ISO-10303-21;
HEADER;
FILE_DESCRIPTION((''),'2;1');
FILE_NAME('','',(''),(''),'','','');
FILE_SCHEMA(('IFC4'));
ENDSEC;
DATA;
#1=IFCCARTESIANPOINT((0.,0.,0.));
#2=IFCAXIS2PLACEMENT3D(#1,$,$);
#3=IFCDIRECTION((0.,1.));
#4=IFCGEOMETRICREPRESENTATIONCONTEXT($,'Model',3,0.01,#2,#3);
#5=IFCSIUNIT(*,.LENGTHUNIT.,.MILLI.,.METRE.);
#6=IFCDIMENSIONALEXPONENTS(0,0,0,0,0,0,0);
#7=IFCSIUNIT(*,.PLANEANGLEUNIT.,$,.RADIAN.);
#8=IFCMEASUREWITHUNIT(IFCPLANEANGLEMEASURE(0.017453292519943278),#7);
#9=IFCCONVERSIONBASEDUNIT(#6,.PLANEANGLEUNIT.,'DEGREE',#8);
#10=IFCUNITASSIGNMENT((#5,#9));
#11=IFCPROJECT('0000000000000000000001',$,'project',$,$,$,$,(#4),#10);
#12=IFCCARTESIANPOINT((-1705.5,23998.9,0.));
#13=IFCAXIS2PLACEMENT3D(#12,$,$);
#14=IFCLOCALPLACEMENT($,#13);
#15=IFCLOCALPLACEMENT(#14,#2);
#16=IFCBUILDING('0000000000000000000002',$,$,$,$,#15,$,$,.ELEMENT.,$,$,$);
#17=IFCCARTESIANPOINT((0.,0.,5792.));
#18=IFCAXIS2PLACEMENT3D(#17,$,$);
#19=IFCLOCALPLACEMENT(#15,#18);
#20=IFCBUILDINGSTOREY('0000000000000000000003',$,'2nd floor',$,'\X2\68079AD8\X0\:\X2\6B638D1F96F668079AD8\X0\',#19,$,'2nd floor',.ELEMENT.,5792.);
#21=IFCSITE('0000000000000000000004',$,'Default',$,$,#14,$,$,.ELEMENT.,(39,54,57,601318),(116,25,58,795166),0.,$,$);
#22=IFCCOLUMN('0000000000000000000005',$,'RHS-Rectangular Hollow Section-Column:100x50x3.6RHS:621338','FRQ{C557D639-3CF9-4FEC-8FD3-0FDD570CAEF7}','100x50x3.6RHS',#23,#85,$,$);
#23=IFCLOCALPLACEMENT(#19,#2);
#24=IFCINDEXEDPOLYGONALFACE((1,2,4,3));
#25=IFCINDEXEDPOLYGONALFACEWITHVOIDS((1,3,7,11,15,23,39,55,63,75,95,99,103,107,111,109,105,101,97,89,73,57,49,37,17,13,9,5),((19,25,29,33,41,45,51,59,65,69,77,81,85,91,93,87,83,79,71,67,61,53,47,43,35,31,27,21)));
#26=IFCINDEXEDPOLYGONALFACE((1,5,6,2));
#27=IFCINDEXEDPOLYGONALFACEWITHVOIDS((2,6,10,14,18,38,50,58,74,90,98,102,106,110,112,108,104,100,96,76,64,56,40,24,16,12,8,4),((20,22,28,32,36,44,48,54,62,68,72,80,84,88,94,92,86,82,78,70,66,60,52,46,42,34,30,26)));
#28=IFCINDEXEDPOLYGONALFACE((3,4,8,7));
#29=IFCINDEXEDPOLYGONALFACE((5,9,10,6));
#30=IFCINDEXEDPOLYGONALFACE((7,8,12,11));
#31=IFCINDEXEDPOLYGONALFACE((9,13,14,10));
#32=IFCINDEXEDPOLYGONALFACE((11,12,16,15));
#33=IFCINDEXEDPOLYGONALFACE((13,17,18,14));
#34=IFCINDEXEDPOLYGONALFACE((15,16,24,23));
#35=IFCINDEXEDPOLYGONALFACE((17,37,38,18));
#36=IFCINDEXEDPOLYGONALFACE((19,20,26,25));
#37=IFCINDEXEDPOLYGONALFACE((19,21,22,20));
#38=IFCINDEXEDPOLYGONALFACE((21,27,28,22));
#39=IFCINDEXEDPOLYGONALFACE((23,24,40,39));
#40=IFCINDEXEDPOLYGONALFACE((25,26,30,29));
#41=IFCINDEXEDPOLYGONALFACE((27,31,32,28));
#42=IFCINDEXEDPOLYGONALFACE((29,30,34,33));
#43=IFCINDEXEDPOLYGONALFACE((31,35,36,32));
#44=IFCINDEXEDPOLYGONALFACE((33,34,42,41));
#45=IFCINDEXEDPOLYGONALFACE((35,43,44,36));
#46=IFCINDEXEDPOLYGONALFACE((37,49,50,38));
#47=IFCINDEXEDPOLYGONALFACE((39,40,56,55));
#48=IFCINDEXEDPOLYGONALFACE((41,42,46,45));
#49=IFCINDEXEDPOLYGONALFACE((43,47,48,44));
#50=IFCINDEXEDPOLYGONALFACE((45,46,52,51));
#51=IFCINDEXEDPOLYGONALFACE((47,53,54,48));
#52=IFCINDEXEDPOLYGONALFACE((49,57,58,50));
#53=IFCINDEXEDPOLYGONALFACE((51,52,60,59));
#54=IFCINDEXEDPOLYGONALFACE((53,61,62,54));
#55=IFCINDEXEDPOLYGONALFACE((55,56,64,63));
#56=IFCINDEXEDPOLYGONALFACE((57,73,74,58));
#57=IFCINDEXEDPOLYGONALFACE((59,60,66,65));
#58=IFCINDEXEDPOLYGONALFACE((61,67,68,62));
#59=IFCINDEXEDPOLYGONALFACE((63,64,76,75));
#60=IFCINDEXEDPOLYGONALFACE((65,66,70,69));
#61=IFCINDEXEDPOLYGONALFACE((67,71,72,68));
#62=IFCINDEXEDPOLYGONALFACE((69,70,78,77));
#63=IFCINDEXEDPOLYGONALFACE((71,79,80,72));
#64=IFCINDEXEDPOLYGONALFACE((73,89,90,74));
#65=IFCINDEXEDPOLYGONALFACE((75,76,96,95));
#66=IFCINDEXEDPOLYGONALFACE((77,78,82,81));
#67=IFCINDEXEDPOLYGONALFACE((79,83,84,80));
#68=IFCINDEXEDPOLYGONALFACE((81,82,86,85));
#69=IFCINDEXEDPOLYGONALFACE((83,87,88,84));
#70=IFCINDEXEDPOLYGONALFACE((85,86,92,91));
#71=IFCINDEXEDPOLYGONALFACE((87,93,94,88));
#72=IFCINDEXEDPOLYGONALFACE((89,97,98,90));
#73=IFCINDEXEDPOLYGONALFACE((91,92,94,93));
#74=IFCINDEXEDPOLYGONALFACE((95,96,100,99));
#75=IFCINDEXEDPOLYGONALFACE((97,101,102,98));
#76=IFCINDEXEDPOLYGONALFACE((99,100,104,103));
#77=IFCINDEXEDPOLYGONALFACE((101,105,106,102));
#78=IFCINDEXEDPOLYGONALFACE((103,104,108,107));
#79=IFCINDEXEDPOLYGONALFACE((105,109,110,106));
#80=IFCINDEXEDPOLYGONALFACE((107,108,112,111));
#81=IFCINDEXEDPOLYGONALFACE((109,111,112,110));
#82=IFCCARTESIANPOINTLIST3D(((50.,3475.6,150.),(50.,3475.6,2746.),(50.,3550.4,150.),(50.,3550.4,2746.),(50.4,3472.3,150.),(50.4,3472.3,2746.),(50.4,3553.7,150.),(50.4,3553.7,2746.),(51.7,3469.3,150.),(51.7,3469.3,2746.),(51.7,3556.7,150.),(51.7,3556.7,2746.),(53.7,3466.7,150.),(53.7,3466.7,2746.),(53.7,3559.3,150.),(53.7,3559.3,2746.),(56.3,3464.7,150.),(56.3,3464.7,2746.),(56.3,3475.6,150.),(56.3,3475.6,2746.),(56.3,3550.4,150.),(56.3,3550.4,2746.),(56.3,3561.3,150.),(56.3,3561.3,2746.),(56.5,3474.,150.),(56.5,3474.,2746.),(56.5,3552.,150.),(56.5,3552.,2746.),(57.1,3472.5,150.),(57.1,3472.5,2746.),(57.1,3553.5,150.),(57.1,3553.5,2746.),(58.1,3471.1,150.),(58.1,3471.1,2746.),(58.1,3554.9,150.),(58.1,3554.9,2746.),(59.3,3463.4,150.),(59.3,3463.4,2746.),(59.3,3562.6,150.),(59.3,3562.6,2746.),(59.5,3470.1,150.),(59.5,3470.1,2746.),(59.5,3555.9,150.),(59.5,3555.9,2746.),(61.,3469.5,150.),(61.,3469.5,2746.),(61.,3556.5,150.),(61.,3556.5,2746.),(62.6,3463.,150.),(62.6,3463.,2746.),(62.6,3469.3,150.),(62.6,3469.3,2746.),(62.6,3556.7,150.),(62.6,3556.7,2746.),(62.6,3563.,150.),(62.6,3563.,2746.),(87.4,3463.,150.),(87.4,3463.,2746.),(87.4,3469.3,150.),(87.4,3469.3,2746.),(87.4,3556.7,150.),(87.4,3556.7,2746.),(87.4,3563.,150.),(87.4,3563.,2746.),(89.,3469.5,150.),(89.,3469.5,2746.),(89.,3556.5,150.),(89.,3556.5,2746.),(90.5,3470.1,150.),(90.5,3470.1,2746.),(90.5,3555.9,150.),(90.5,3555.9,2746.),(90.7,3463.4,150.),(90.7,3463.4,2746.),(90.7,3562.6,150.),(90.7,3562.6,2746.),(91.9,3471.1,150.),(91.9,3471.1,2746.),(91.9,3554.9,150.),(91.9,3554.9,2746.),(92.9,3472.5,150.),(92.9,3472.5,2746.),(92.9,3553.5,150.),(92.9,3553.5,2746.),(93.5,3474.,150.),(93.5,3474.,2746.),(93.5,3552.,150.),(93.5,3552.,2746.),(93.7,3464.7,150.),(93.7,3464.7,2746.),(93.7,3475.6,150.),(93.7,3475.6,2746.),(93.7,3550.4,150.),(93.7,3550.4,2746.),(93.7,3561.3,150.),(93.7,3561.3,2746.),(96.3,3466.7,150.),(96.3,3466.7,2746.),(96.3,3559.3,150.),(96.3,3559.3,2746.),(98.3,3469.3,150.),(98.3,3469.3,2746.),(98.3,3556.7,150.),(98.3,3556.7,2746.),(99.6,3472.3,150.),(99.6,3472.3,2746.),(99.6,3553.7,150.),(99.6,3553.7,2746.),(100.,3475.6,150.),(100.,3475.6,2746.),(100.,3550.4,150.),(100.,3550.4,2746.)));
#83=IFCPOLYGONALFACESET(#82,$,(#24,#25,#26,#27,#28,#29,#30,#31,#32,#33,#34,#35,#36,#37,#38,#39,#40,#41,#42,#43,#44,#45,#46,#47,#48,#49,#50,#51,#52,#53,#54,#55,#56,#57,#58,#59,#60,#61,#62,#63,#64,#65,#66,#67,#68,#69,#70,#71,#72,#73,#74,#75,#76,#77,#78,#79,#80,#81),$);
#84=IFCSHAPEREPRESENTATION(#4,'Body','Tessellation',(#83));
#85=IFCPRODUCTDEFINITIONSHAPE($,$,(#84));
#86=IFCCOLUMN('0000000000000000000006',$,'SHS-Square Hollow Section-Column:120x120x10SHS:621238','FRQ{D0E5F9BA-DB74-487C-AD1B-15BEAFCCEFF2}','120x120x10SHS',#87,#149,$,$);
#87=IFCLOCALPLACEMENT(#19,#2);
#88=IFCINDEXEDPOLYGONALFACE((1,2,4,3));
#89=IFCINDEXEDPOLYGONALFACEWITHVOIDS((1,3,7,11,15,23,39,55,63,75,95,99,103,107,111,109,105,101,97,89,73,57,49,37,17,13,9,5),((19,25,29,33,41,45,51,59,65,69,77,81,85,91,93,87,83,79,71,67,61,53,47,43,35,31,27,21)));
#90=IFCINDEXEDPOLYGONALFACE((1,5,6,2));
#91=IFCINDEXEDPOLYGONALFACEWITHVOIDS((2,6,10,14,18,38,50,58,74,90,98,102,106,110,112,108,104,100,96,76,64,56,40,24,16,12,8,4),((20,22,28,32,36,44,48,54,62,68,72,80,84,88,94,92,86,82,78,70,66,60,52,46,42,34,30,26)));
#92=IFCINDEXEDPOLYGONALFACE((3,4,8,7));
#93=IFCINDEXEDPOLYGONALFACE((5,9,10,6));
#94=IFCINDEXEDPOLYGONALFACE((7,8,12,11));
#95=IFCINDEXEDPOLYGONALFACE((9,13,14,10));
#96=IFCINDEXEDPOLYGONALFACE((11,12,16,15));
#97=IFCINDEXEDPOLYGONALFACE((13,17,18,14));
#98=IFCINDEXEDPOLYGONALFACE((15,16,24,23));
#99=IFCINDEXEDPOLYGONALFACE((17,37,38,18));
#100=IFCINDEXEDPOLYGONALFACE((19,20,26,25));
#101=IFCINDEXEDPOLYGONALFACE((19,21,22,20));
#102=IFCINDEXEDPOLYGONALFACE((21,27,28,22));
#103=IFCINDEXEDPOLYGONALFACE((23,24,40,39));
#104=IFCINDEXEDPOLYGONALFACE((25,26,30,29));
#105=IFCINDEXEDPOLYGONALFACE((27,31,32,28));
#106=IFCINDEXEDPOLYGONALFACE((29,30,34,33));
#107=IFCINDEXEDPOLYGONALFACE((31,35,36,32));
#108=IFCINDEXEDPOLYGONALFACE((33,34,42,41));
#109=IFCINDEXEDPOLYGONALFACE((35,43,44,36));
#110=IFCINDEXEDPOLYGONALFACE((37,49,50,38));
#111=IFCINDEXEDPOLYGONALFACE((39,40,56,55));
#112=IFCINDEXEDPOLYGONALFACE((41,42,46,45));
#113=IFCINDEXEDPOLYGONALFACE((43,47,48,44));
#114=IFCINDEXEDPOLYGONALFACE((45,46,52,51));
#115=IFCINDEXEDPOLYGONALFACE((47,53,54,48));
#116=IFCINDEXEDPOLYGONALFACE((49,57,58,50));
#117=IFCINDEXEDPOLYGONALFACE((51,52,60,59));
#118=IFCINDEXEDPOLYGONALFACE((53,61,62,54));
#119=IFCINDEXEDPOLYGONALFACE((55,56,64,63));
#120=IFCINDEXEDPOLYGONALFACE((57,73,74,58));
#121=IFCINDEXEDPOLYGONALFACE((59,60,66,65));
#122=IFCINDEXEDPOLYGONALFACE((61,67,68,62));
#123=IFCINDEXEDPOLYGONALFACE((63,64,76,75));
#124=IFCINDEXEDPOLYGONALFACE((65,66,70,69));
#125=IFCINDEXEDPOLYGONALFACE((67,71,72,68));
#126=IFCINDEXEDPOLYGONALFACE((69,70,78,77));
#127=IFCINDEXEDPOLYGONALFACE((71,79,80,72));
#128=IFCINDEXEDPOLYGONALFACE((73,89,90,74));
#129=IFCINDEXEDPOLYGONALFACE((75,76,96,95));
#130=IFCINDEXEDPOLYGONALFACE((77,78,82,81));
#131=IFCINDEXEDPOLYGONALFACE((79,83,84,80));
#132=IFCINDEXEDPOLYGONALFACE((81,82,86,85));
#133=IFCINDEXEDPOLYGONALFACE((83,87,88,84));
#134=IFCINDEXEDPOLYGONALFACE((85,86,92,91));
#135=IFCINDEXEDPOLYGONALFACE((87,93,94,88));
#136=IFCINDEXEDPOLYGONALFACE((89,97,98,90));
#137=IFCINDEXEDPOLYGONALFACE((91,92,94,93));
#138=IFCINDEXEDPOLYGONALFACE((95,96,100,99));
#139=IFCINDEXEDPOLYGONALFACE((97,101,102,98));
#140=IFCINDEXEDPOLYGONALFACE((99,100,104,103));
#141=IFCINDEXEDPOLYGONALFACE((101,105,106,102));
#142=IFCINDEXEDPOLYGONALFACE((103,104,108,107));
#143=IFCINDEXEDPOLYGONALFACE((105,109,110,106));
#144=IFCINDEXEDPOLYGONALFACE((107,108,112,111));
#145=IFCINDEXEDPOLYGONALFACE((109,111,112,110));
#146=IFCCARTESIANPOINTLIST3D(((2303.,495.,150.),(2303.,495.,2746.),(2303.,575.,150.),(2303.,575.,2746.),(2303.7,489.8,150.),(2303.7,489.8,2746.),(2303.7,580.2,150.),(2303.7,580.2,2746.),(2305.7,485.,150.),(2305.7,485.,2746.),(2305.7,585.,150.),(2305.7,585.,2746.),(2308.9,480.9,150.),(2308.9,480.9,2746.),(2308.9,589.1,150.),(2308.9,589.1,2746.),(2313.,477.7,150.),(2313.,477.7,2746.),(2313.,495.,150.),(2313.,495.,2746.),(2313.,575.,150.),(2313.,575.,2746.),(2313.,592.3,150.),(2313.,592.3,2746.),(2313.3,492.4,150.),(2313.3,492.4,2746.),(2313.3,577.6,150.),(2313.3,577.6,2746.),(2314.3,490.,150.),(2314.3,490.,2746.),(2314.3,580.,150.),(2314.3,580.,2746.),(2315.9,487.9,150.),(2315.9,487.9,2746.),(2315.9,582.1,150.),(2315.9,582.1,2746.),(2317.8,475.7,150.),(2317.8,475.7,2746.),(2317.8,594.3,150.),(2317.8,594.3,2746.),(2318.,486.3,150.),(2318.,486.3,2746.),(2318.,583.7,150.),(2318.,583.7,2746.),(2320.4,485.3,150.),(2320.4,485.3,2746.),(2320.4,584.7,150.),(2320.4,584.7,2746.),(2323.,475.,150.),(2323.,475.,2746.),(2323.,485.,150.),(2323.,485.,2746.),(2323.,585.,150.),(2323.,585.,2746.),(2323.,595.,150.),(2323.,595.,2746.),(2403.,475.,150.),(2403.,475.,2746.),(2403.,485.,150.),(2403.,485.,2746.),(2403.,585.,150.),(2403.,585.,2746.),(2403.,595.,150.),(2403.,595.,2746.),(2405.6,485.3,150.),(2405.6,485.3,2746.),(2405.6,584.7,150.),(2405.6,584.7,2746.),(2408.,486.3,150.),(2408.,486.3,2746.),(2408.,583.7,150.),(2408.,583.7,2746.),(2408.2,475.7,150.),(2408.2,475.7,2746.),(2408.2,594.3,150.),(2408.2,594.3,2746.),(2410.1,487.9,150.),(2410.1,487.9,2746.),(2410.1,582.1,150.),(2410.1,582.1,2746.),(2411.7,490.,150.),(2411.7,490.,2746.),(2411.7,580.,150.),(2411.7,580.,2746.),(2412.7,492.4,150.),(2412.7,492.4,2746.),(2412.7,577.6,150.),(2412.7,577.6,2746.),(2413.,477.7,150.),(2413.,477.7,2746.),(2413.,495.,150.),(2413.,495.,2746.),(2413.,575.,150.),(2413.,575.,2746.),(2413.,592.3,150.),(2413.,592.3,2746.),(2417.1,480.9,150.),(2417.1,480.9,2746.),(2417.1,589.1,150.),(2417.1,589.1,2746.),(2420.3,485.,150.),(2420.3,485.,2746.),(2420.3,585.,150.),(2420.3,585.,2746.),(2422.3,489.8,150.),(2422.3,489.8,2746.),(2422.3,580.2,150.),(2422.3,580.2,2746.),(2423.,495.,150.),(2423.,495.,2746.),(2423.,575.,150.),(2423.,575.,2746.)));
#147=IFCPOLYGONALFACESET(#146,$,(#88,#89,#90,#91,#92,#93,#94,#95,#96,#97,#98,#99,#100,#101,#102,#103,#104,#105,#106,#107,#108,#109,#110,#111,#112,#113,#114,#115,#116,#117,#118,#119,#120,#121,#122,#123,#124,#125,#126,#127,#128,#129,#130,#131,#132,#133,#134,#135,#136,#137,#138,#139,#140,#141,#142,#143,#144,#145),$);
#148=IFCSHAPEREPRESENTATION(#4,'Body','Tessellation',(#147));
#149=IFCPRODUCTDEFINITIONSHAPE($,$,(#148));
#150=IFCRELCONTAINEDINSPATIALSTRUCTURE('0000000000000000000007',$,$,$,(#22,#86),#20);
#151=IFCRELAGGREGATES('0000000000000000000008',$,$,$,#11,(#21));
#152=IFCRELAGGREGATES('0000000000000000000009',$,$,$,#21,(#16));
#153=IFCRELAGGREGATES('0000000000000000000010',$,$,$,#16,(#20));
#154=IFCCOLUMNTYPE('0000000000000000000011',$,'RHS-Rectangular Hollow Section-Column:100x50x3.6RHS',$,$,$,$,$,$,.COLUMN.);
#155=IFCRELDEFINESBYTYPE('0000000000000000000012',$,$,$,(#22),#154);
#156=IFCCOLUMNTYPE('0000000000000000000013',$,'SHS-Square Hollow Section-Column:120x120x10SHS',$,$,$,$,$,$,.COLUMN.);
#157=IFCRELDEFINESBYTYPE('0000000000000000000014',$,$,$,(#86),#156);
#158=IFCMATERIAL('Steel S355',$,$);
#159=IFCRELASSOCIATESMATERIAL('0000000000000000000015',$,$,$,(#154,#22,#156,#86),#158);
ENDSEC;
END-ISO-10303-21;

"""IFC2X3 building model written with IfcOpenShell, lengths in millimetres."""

from ifc_helpers import new_model, entity, si_unit, converted_unit, direction, frame, origin, origin_2d, place, context, project, spatial, hollow_rectangle, extrude, clip, halfspace, material, type_object, element, save


model = new_model("IFC2X3")

# Units and contexts
model_context = context("Model", 3, precision=0.01, world=origin(), true_north=direction((0.0, 1.0)))
ifc_project = project(units=[si_unit("LENGTHUNIT", "METRE", prefix="MILLI"), converted_unit("PLANEANGLEUNIT", "DEGREE", entity("IfcPlaneAngleMeasure", 0.017453292519943278), si_unit("PLANEANGLEUNIT", "RADIAN"), dimensions=[0, 0, 0, 0, 0, 0, 0])], contexts=[model_context])

# Site, building, storey
site_placement = place(None, frame((-1705.5, 23998.9, 0.0)))
site = spatial("IfcSite", under=ifc_project, at=site_placement, Name="Default", CompositionType="ELEMENT", RefLatitude=(39, 54, 57, 601318), RefLongitude=(116, 25, 58, 795166), RefElevation=0.0)
building_placement = place(site_placement, origin())
building = spatial("IfcBuilding", under=site, at=building_placement, CompositionType="ELEMENT")
storey_placement = place(building_placement, frame((0.0, 0.0, 5792.0)))
storey = spatial("IfcBuildingStorey", under=building, at=storey_placement, Name="2nd floor", ObjectType="标高:正负零标高", LongName="2nd floor", CompositionType="ELEMENT", Elevation=5792.0)

# Columns
ifc_material_1 = material(Name="Steel S355")
column_type_1 = type_object("IfcColumnType", Name="RHS-Rectangular Hollow Section-Column:100x50x3.6RHS", PredefinedType="COLUMN", material=ifc_material_1)
column_1_placement = place(storey_placement, frame((75.0, 3513.0, 2746.0), z_axis=(0.0, 0.0, 1.0), x_axis=(-1.0, 0.0, 0.0)))
element("IfcColumn", 1, at=column_1_placement, inside=storey, type_object=column_type_1, material=ifc_material_1, Name="RHS-Rectangular Hollow Section-Column:100x50x3.6RHS:621338", Description="FRQ{C557D639-3CF9-4FEC-8FD3-0FDD570CAEF7}", ObjectType="100x50x3.6RHS", context=model_context, shape_type="Clipping", body=[
    clip(extrude(hollow_rectangle(XDim=50.0, YDim=100.0, WallThickness=6.3, InnerFilletRadius=6.3, OuterFilletRadius=12.6, at=origin_2d()), origin(), (0.0, 0.0, -1.0), 2651.9), halfspace(frame((75.0, 3513.0, -2596.0), z_axis=(0.0, 0.0, 1.0), x_axis=(-1.0, 0.0, 0.0)), True)),
])
column_type_2 = type_object("IfcColumnType", Name="SHS-Square Hollow Section-Column:120x120x10SHS", PredefinedType="COLUMN", material=ifc_material_1)
column_2_placement = place(storey_placement, frame((2363.0, 535.0, 2746.0), z_axis=(0.0, 0.0, 1.0), x_axis=(0.0, -1.0, 0.0)))
element("IfcColumn", 2, at=column_2_placement, inside=storey, type_object=column_type_2, material=ifc_material_1, Name="SHS-Square Hollow Section-Column:120x120x10SHS:621238", Description="FRQ{D0E5F9BA-DB74-487C-AD1B-15BEAFCCEFF2}", ObjectType="120x120x10SHS", context=model_context, shape_type="Clipping", body=[
    clip(extrude(hollow_rectangle(XDim=120.0, YDim=120.0, WallThickness=10.0, InnerFilletRadius=10.0, OuterFilletRadius=20.0, at=origin_2d()), origin(), (0.0, 0.0, -1.0), 2680.9), halfspace(frame((535.0, -2363.0, -2596.0), z_axis=(0.0, 0.0, 1.0), x_axis=(0.0, 1.0, 0.0)), True)),
])

save(model, "model.ifc")
